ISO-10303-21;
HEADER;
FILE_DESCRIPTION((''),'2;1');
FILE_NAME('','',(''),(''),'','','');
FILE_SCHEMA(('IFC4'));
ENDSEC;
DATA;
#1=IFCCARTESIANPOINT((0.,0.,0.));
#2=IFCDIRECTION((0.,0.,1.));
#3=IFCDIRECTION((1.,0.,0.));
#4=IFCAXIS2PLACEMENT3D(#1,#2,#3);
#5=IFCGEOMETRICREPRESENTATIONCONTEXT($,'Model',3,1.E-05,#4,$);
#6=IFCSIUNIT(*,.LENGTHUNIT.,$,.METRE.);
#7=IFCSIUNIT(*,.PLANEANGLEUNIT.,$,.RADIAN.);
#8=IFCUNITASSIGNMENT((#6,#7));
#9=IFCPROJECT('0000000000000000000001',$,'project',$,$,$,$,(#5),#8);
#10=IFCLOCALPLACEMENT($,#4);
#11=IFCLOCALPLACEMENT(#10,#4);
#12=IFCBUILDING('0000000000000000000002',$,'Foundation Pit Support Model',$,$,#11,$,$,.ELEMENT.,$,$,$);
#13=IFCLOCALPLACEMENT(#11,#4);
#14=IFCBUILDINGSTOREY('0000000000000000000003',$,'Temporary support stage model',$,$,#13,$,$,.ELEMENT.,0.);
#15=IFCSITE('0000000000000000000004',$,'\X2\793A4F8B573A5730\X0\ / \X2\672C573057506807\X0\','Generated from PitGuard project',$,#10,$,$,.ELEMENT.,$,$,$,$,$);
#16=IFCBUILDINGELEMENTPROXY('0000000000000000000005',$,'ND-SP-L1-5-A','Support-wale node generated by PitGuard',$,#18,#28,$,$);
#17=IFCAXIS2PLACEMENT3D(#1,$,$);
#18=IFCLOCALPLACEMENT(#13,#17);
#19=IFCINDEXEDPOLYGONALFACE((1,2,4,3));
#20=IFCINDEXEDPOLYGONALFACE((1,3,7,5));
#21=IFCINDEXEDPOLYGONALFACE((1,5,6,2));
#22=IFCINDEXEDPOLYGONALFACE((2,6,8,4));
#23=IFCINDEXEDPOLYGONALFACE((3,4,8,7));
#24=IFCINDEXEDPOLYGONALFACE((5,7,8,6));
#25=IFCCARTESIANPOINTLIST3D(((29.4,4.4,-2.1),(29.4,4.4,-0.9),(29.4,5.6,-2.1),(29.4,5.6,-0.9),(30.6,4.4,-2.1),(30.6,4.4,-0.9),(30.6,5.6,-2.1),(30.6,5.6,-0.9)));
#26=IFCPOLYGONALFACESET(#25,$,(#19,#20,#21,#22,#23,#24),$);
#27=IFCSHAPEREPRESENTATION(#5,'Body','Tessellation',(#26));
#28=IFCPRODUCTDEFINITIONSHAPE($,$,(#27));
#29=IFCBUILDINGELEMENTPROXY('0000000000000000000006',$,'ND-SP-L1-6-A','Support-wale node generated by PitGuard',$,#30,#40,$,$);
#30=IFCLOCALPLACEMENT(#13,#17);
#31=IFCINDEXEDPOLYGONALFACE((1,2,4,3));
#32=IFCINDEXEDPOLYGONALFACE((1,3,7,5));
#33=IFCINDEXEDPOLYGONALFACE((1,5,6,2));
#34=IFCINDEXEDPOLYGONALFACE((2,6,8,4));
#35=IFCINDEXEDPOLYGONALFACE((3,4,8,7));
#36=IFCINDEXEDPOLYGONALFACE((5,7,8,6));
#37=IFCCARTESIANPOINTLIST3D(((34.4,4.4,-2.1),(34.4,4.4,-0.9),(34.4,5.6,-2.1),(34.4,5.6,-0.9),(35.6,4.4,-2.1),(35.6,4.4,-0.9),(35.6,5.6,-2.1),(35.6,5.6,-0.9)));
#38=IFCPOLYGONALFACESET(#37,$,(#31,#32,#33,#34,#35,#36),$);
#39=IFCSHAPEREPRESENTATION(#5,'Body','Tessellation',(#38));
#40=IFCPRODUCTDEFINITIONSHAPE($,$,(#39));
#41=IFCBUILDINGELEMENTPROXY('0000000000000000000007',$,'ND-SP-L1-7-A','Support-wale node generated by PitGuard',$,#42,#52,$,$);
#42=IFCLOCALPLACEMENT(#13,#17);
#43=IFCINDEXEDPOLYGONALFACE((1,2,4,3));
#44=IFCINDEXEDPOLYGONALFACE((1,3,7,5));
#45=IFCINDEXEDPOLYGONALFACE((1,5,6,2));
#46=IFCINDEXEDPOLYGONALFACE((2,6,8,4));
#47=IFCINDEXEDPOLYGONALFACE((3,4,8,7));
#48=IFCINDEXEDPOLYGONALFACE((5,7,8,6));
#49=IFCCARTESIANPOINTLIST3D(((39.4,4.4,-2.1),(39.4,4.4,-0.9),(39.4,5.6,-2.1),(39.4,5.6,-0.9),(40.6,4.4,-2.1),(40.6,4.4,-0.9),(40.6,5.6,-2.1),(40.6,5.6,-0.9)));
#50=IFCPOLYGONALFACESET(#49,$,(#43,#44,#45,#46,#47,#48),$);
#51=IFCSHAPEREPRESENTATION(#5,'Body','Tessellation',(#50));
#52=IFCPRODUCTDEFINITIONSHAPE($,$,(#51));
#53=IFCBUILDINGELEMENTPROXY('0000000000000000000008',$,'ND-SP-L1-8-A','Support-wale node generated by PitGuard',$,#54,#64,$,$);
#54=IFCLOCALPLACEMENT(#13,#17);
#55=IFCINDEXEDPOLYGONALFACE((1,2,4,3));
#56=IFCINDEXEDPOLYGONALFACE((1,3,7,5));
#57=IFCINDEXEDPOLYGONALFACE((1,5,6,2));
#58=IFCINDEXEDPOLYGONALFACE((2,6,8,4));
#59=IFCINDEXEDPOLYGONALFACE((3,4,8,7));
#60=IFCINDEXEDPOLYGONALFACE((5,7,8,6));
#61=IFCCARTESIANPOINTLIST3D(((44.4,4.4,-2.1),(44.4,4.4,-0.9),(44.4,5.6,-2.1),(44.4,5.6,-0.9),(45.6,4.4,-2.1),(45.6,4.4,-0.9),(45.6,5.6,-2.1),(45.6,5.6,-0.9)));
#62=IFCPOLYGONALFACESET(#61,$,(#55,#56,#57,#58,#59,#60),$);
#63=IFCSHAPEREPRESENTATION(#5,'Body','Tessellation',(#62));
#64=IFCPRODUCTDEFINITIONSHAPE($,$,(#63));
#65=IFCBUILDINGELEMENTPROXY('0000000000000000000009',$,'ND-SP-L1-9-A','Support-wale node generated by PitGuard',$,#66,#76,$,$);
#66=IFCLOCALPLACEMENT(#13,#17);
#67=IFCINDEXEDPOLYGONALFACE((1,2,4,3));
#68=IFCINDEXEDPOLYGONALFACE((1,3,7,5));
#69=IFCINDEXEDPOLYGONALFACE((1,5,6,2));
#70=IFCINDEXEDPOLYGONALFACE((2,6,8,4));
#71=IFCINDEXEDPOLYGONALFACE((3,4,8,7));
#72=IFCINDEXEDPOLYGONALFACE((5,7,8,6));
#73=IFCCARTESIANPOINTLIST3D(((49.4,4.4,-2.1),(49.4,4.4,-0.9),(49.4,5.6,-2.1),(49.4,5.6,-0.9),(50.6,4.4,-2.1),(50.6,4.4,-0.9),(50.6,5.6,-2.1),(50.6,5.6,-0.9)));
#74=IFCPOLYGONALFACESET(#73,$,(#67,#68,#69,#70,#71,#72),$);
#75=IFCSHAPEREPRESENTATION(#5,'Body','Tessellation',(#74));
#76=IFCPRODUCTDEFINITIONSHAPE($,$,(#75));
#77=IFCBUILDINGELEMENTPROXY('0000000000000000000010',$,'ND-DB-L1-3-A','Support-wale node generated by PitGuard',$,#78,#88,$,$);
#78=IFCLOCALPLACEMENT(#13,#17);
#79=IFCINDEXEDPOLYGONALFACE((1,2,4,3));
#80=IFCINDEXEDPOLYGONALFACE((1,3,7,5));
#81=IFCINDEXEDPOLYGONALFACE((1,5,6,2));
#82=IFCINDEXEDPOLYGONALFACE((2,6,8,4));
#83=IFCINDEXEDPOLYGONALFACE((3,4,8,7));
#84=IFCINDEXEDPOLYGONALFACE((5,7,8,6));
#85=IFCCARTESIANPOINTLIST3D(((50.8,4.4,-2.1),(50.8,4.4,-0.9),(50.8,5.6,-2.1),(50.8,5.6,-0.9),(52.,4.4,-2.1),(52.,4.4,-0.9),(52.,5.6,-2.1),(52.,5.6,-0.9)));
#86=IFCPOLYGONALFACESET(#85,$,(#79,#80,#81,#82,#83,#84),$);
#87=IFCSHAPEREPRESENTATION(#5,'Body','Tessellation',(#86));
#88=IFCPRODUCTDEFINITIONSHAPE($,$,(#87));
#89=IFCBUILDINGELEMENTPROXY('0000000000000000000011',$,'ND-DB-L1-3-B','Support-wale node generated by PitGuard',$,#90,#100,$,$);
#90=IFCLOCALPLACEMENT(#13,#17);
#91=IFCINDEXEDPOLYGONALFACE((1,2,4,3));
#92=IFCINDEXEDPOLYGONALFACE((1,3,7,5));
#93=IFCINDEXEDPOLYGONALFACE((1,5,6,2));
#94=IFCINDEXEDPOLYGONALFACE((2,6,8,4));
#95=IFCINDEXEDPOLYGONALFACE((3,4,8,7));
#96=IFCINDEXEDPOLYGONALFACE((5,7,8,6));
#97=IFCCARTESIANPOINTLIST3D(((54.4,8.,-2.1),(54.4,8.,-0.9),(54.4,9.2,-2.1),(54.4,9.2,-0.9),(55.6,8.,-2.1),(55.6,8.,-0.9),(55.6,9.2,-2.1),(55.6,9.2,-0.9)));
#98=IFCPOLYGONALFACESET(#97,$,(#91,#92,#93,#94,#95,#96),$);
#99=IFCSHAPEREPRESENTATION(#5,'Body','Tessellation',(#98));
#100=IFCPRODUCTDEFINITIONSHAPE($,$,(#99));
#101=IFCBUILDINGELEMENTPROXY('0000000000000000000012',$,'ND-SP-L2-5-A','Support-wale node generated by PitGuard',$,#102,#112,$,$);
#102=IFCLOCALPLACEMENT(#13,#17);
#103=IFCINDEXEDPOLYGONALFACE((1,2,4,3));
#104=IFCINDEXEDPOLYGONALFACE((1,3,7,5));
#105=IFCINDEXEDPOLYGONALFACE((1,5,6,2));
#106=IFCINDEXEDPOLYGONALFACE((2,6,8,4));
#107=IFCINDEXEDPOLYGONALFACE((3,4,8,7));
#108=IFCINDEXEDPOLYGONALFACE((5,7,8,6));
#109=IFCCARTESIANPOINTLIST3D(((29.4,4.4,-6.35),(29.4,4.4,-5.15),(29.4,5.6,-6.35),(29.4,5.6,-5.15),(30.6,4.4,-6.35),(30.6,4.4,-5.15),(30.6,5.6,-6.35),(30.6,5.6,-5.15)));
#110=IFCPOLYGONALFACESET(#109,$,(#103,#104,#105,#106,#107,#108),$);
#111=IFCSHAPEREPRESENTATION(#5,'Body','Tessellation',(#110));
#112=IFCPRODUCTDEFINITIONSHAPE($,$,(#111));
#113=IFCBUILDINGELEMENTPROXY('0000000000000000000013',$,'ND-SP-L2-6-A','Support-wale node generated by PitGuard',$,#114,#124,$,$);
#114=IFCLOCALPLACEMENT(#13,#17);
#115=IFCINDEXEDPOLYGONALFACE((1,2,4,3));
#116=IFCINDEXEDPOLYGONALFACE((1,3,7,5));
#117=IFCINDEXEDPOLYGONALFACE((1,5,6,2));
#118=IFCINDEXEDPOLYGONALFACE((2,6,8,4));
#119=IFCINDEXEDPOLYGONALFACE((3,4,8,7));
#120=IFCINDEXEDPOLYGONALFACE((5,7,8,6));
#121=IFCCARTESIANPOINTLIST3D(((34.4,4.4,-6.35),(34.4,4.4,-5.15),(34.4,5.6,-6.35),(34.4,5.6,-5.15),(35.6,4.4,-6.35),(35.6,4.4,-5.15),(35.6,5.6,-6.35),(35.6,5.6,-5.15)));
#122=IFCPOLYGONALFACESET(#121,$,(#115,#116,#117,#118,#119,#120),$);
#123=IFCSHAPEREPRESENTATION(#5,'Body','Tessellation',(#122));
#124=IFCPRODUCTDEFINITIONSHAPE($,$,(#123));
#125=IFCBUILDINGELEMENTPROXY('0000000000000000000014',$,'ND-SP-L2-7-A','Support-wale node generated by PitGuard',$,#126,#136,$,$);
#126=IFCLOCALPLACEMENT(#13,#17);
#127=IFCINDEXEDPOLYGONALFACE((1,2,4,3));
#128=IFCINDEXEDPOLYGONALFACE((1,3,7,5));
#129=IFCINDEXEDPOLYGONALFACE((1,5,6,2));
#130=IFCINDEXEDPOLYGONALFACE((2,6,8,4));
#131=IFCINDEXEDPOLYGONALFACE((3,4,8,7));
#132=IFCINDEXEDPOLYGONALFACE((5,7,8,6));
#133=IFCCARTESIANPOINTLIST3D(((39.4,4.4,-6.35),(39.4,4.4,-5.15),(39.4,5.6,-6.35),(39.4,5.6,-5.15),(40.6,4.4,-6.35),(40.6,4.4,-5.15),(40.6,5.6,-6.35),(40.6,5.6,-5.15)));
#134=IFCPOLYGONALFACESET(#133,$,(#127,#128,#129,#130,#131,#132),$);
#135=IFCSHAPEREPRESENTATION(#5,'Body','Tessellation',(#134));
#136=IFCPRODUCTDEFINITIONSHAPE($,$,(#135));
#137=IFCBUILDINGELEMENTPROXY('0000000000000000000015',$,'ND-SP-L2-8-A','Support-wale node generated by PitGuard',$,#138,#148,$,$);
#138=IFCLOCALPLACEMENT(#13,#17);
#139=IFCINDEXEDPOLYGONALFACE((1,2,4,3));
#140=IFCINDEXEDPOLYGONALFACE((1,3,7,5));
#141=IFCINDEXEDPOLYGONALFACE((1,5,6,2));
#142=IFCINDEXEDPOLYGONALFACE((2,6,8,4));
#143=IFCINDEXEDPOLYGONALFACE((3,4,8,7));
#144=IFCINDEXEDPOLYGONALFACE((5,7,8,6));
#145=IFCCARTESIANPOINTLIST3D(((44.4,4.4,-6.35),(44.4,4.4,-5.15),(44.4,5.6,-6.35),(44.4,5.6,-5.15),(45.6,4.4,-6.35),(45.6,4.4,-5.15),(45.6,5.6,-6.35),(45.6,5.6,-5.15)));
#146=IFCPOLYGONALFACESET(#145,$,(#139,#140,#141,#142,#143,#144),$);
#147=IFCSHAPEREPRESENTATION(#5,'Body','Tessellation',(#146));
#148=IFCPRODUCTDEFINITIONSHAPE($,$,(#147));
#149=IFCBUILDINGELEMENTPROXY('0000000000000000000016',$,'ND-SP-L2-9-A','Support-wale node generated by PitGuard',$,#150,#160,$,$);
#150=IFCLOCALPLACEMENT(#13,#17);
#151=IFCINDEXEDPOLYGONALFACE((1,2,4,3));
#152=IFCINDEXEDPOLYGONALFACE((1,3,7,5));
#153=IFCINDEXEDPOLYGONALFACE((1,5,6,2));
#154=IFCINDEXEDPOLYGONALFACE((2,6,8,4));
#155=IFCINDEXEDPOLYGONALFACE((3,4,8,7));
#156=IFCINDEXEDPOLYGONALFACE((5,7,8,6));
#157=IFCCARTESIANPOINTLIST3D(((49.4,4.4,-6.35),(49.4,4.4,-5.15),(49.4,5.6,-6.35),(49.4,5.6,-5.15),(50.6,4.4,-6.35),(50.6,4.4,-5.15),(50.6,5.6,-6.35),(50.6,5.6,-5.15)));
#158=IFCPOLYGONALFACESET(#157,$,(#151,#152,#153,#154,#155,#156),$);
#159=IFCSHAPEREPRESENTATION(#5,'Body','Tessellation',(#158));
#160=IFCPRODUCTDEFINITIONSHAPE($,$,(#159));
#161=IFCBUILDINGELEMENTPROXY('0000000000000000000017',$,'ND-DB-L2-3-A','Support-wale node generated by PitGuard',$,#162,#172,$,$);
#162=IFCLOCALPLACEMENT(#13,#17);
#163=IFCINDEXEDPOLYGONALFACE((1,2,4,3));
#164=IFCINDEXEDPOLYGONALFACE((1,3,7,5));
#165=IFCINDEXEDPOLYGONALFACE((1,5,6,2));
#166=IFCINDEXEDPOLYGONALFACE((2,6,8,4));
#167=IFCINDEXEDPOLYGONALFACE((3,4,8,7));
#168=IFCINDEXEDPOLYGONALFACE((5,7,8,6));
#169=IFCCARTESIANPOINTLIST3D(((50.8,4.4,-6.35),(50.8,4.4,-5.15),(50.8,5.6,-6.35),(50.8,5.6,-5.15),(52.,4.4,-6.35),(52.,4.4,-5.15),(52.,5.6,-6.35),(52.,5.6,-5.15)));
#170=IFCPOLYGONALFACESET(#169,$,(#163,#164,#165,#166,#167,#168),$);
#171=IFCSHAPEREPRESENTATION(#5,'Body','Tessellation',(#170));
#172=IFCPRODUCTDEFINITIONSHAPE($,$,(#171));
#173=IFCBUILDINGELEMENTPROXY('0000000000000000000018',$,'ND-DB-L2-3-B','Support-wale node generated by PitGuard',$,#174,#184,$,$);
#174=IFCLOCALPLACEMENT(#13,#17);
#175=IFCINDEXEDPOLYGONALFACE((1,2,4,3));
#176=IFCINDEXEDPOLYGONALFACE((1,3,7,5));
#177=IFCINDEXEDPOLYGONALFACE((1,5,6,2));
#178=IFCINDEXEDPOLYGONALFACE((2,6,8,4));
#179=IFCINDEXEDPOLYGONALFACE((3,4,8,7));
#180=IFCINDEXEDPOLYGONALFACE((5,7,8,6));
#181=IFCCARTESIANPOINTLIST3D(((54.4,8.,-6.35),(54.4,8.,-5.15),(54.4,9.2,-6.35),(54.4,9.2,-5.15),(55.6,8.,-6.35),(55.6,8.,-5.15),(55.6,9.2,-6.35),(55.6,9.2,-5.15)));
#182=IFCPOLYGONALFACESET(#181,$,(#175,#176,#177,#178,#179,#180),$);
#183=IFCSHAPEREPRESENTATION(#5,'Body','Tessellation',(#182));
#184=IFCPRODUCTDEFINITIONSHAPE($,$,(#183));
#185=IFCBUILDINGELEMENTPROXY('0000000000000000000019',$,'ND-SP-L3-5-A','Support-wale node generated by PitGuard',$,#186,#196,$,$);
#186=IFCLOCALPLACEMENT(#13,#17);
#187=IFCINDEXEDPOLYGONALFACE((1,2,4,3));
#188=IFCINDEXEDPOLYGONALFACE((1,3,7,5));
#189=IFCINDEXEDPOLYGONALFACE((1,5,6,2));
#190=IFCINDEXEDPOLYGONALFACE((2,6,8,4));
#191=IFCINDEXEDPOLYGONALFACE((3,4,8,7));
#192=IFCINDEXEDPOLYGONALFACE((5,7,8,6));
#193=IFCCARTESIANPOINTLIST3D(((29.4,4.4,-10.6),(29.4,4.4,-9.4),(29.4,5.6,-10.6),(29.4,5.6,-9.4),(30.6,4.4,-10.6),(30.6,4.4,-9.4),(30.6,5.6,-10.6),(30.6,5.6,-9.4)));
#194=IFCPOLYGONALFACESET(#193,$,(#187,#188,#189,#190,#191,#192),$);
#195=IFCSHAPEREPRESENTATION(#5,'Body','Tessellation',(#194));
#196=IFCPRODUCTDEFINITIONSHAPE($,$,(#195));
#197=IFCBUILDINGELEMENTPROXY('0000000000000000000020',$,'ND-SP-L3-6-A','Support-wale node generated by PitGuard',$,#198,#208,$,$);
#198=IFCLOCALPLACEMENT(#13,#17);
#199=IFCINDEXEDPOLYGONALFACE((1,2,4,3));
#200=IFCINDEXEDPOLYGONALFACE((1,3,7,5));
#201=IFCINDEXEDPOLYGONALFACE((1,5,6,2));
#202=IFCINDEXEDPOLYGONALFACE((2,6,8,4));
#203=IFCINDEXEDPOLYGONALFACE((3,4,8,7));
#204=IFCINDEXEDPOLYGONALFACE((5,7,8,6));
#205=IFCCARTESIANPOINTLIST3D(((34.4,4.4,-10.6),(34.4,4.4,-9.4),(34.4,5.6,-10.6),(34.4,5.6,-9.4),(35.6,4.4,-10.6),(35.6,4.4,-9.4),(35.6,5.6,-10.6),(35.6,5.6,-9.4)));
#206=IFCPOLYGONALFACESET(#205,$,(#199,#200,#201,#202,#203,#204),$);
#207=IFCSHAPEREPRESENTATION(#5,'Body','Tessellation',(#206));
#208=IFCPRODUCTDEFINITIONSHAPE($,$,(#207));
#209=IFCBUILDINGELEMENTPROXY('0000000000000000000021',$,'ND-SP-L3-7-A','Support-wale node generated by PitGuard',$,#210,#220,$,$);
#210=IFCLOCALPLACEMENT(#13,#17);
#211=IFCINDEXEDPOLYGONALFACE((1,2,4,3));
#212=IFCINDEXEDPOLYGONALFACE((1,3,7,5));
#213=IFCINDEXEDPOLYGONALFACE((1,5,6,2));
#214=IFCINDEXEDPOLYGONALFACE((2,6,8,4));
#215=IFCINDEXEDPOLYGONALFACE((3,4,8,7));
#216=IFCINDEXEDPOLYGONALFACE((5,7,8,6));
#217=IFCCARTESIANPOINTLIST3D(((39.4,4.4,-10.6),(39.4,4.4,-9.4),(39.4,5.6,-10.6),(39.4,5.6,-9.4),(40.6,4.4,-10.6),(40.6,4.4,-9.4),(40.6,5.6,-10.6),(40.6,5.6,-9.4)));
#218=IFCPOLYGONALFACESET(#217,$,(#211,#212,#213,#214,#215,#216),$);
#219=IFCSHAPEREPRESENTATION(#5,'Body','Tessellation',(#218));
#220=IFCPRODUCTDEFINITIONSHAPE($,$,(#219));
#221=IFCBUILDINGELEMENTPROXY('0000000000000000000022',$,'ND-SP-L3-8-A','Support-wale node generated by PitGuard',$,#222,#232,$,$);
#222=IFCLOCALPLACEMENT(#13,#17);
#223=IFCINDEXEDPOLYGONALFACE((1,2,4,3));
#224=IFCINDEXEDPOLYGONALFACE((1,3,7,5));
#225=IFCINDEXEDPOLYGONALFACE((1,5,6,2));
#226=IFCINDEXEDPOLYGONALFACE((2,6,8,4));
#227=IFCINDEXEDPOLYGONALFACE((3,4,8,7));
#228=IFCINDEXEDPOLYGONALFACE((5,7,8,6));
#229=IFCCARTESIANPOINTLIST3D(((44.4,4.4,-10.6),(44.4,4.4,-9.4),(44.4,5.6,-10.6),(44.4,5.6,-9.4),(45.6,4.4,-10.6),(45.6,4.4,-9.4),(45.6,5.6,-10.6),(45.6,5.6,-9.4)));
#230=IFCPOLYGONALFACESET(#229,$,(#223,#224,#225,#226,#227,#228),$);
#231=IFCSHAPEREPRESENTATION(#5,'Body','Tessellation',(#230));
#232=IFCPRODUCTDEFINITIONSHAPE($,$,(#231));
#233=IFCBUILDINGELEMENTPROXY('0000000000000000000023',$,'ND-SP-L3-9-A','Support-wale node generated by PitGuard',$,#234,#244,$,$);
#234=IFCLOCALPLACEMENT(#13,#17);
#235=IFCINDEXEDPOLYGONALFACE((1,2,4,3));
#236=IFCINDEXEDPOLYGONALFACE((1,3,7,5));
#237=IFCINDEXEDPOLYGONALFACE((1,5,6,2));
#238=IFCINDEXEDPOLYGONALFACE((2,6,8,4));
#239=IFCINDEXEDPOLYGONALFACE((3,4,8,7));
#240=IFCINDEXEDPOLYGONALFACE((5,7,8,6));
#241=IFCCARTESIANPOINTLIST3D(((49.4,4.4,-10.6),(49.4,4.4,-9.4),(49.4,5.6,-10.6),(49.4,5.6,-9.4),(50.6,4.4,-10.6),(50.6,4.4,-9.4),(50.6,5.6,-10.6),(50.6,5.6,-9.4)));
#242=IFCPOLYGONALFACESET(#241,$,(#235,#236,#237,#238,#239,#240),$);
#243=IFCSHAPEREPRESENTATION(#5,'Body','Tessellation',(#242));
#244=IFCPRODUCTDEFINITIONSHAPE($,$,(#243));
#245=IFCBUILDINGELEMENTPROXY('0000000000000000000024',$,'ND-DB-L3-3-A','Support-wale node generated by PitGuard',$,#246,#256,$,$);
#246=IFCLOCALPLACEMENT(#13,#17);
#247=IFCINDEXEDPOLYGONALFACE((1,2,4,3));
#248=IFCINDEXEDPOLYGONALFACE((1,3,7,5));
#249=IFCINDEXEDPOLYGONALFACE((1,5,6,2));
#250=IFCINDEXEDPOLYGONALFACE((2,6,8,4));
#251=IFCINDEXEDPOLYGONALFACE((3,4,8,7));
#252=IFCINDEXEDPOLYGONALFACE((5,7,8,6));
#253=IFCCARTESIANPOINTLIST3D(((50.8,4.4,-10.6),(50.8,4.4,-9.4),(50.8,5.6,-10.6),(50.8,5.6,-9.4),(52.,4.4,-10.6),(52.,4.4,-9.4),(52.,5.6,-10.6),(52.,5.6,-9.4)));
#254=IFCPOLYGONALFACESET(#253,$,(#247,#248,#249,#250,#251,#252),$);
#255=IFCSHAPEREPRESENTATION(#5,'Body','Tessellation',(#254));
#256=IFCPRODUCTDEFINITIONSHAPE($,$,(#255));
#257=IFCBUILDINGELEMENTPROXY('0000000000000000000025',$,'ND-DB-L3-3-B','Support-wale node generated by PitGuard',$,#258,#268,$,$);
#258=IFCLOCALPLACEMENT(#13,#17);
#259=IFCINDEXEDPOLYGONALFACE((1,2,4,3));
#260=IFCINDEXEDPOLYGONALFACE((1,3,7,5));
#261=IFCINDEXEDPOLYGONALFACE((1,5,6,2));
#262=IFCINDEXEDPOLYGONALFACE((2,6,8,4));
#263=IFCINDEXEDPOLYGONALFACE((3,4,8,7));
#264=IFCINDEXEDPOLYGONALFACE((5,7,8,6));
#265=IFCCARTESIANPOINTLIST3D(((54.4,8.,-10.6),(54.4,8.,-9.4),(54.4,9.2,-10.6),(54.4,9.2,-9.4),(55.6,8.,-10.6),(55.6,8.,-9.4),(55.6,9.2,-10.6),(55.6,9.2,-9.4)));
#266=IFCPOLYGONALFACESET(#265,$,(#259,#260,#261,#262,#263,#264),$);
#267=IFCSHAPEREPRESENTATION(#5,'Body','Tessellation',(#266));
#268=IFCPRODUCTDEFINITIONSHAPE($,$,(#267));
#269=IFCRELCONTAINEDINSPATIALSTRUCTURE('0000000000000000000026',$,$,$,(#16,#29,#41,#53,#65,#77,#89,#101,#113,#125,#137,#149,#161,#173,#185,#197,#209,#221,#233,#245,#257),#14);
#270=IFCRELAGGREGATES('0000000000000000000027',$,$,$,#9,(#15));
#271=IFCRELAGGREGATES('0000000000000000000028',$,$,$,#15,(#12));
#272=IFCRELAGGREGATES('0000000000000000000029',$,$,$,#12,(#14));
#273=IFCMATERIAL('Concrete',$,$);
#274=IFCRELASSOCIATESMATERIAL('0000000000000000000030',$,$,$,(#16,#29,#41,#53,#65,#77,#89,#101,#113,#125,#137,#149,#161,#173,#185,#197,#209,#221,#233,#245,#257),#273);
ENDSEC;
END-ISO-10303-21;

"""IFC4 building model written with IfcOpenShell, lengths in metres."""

from ifc_helpers import new_model, si_unit, frame, origin_with_axes, origin_2d, place, context, project, spatial, rectangle, extrude, material, element, save


model = new_model("IFC4")

# Units and contexts
model_context = context("Model", 3, precision=1e-05, world=origin_with_axes())
ifc_project = project(units=[si_unit("LENGTHUNIT", "METRE"), si_unit("PLANEANGLEUNIT", "RADIAN")], contexts=[model_context])

# Site, building, storey
site_placement = place(None, origin_with_axes())
site = spatial("IfcSite", under=ifc_project, at=site_placement, Name="示例场地 / 本地坐标", Description="Generated from PitGuard project", CompositionType="ELEMENT")
building_placement = place(site_placement, origin_with_axes())
building = spatial("IfcBuilding", under=site, at=building_placement, Name="Foundation Pit Support Model", CompositionType="ELEMENT")
storey_placement = place(building_placement, origin_with_axes())
storey = spatial("IfcBuildingStorey", under=building, at=storey_placement, Name="Temporary support stage model", CompositionType="ELEMENT", Elevation=0.0)

# Shared definitions
ifc_material_1 = material(Name="Concrete")

# Building element proxies
for number, where, z_axis, x_axis, name in (
    (1, (30.0, 5.0, -2.1), (0.0, 0.0, 1.0), (1.0, 0.0, 0.0), "ND-SP-L1-5-A"),
    (2, (35.0, 5.0, -2.1), (0.0, 0.0, 1.0), (1.0, 0.0, 0.0), "ND-SP-L1-6-A"),
    (3, (40.0, 5.0, -2.1), (0.0, 0.0, 1.0), (1.0, 0.0, 0.0), "ND-SP-L1-7-A"),
    (4, (45.0, 5.0, -2.1), (0.0, 0.0, 1.0), (1.0, 0.0, 0.0), "ND-SP-L1-8-A"),
    (5, (50.0, 5.0, -2.1), (0.0, 0.0, 1.0), (1.0, 0.0, 0.0), "ND-SP-L1-9-A"),
    (6, (51.4, 5.0, -2.1), (0.0, 0.0, 1.0), (1.0, 0.0, 0.0), "ND-DB-L1-3-A"),
    (7, (55.0, 8.6, -2.1), (0.0, 0.0, 1.0), (1.0, 0.0, 0.0), "ND-DB-L1-3-B"),
    (8, (30.0, 5.0, -6.35), (0.0, 0.0, 1.0), (1.0, 0.0, 0.0), "ND-SP-L2-5-A"),
    (9, (35.0, 5.0, -6.35), (0.0, 0.0, 1.0), (1.0, 0.0, 0.0), "ND-SP-L2-6-A"),
    (10, (40.0, 5.0, -6.35), (0.0, 0.0, 1.0), (1.0, 0.0, 0.0), "ND-SP-L2-7-A"),
    (11, (45.0, 5.0, -6.35), (0.0, 0.0, 1.0), (1.0, 0.0, 0.0), "ND-SP-L2-8-A"),
    (12, (50.0, 5.0, -6.35), (0.0, 0.0, 1.0), (1.0, 0.0, 0.0), "ND-SP-L2-9-A"),
    (13, (51.4, 5.0, -6.35), (0.0, 0.0, 1.0), (1.0, 0.0, 0.0), "ND-DB-L2-3-A"),
    (14, (55.0, 8.6, -6.35), (0.0, 0.0, 1.0), (1.0, 0.0, 0.0), "ND-DB-L2-3-B"),
    (15, (30.0, 5.0, -10.6), (0.0, 0.0, 1.0), (1.0, 0.0, 0.0), "ND-SP-L3-5-A"),
    (16, (35.0, 5.0, -10.6), (0.0, 0.0, 1.0), (1.0, 0.0, 0.0), "ND-SP-L3-6-A"),
    (17, (40.0, 5.0, -10.6), (0.0, 0.0, 1.0), (1.0, 0.0, 0.0), "ND-SP-L3-7-A"),
    (18, (45.0, 5.0, -10.6), (0.0, 0.0, 1.0), (1.0, 0.0, 0.0), "ND-SP-L3-8-A"),
    (19, (50.0, 5.0, -10.6), (0.0, 0.0, 1.0), (1.0, 0.0, 0.0), "ND-SP-L3-9-A"),
    (20, (51.4, 5.0, -10.6), (0.0, 0.0, 1.0), (1.0, 0.0, 0.0), "ND-DB-L3-3-A"),
    (21, (55.0, 8.6, -10.6), (0.0, 0.0, 1.0), (1.0, 0.0, 0.0), "ND-DB-L3-3-B"),
):
    element("IfcBuildingElementProxy", number, at=place(storey_placement, frame(where, z_axis=z_axis, x_axis=x_axis)), inside=storey, material=ifc_material_1, Name=name, Description="Support-wale node generated by PitGuard", context=model_context, shape_type="SweptSolid", body=[
        extrude(rectangle(XDim=1.2, YDim=1.2, at=origin_2d()), origin_with_axes(), (0.0, 0.0, 1.0), 1.2),
    ])

save(model, "model.ifc")
